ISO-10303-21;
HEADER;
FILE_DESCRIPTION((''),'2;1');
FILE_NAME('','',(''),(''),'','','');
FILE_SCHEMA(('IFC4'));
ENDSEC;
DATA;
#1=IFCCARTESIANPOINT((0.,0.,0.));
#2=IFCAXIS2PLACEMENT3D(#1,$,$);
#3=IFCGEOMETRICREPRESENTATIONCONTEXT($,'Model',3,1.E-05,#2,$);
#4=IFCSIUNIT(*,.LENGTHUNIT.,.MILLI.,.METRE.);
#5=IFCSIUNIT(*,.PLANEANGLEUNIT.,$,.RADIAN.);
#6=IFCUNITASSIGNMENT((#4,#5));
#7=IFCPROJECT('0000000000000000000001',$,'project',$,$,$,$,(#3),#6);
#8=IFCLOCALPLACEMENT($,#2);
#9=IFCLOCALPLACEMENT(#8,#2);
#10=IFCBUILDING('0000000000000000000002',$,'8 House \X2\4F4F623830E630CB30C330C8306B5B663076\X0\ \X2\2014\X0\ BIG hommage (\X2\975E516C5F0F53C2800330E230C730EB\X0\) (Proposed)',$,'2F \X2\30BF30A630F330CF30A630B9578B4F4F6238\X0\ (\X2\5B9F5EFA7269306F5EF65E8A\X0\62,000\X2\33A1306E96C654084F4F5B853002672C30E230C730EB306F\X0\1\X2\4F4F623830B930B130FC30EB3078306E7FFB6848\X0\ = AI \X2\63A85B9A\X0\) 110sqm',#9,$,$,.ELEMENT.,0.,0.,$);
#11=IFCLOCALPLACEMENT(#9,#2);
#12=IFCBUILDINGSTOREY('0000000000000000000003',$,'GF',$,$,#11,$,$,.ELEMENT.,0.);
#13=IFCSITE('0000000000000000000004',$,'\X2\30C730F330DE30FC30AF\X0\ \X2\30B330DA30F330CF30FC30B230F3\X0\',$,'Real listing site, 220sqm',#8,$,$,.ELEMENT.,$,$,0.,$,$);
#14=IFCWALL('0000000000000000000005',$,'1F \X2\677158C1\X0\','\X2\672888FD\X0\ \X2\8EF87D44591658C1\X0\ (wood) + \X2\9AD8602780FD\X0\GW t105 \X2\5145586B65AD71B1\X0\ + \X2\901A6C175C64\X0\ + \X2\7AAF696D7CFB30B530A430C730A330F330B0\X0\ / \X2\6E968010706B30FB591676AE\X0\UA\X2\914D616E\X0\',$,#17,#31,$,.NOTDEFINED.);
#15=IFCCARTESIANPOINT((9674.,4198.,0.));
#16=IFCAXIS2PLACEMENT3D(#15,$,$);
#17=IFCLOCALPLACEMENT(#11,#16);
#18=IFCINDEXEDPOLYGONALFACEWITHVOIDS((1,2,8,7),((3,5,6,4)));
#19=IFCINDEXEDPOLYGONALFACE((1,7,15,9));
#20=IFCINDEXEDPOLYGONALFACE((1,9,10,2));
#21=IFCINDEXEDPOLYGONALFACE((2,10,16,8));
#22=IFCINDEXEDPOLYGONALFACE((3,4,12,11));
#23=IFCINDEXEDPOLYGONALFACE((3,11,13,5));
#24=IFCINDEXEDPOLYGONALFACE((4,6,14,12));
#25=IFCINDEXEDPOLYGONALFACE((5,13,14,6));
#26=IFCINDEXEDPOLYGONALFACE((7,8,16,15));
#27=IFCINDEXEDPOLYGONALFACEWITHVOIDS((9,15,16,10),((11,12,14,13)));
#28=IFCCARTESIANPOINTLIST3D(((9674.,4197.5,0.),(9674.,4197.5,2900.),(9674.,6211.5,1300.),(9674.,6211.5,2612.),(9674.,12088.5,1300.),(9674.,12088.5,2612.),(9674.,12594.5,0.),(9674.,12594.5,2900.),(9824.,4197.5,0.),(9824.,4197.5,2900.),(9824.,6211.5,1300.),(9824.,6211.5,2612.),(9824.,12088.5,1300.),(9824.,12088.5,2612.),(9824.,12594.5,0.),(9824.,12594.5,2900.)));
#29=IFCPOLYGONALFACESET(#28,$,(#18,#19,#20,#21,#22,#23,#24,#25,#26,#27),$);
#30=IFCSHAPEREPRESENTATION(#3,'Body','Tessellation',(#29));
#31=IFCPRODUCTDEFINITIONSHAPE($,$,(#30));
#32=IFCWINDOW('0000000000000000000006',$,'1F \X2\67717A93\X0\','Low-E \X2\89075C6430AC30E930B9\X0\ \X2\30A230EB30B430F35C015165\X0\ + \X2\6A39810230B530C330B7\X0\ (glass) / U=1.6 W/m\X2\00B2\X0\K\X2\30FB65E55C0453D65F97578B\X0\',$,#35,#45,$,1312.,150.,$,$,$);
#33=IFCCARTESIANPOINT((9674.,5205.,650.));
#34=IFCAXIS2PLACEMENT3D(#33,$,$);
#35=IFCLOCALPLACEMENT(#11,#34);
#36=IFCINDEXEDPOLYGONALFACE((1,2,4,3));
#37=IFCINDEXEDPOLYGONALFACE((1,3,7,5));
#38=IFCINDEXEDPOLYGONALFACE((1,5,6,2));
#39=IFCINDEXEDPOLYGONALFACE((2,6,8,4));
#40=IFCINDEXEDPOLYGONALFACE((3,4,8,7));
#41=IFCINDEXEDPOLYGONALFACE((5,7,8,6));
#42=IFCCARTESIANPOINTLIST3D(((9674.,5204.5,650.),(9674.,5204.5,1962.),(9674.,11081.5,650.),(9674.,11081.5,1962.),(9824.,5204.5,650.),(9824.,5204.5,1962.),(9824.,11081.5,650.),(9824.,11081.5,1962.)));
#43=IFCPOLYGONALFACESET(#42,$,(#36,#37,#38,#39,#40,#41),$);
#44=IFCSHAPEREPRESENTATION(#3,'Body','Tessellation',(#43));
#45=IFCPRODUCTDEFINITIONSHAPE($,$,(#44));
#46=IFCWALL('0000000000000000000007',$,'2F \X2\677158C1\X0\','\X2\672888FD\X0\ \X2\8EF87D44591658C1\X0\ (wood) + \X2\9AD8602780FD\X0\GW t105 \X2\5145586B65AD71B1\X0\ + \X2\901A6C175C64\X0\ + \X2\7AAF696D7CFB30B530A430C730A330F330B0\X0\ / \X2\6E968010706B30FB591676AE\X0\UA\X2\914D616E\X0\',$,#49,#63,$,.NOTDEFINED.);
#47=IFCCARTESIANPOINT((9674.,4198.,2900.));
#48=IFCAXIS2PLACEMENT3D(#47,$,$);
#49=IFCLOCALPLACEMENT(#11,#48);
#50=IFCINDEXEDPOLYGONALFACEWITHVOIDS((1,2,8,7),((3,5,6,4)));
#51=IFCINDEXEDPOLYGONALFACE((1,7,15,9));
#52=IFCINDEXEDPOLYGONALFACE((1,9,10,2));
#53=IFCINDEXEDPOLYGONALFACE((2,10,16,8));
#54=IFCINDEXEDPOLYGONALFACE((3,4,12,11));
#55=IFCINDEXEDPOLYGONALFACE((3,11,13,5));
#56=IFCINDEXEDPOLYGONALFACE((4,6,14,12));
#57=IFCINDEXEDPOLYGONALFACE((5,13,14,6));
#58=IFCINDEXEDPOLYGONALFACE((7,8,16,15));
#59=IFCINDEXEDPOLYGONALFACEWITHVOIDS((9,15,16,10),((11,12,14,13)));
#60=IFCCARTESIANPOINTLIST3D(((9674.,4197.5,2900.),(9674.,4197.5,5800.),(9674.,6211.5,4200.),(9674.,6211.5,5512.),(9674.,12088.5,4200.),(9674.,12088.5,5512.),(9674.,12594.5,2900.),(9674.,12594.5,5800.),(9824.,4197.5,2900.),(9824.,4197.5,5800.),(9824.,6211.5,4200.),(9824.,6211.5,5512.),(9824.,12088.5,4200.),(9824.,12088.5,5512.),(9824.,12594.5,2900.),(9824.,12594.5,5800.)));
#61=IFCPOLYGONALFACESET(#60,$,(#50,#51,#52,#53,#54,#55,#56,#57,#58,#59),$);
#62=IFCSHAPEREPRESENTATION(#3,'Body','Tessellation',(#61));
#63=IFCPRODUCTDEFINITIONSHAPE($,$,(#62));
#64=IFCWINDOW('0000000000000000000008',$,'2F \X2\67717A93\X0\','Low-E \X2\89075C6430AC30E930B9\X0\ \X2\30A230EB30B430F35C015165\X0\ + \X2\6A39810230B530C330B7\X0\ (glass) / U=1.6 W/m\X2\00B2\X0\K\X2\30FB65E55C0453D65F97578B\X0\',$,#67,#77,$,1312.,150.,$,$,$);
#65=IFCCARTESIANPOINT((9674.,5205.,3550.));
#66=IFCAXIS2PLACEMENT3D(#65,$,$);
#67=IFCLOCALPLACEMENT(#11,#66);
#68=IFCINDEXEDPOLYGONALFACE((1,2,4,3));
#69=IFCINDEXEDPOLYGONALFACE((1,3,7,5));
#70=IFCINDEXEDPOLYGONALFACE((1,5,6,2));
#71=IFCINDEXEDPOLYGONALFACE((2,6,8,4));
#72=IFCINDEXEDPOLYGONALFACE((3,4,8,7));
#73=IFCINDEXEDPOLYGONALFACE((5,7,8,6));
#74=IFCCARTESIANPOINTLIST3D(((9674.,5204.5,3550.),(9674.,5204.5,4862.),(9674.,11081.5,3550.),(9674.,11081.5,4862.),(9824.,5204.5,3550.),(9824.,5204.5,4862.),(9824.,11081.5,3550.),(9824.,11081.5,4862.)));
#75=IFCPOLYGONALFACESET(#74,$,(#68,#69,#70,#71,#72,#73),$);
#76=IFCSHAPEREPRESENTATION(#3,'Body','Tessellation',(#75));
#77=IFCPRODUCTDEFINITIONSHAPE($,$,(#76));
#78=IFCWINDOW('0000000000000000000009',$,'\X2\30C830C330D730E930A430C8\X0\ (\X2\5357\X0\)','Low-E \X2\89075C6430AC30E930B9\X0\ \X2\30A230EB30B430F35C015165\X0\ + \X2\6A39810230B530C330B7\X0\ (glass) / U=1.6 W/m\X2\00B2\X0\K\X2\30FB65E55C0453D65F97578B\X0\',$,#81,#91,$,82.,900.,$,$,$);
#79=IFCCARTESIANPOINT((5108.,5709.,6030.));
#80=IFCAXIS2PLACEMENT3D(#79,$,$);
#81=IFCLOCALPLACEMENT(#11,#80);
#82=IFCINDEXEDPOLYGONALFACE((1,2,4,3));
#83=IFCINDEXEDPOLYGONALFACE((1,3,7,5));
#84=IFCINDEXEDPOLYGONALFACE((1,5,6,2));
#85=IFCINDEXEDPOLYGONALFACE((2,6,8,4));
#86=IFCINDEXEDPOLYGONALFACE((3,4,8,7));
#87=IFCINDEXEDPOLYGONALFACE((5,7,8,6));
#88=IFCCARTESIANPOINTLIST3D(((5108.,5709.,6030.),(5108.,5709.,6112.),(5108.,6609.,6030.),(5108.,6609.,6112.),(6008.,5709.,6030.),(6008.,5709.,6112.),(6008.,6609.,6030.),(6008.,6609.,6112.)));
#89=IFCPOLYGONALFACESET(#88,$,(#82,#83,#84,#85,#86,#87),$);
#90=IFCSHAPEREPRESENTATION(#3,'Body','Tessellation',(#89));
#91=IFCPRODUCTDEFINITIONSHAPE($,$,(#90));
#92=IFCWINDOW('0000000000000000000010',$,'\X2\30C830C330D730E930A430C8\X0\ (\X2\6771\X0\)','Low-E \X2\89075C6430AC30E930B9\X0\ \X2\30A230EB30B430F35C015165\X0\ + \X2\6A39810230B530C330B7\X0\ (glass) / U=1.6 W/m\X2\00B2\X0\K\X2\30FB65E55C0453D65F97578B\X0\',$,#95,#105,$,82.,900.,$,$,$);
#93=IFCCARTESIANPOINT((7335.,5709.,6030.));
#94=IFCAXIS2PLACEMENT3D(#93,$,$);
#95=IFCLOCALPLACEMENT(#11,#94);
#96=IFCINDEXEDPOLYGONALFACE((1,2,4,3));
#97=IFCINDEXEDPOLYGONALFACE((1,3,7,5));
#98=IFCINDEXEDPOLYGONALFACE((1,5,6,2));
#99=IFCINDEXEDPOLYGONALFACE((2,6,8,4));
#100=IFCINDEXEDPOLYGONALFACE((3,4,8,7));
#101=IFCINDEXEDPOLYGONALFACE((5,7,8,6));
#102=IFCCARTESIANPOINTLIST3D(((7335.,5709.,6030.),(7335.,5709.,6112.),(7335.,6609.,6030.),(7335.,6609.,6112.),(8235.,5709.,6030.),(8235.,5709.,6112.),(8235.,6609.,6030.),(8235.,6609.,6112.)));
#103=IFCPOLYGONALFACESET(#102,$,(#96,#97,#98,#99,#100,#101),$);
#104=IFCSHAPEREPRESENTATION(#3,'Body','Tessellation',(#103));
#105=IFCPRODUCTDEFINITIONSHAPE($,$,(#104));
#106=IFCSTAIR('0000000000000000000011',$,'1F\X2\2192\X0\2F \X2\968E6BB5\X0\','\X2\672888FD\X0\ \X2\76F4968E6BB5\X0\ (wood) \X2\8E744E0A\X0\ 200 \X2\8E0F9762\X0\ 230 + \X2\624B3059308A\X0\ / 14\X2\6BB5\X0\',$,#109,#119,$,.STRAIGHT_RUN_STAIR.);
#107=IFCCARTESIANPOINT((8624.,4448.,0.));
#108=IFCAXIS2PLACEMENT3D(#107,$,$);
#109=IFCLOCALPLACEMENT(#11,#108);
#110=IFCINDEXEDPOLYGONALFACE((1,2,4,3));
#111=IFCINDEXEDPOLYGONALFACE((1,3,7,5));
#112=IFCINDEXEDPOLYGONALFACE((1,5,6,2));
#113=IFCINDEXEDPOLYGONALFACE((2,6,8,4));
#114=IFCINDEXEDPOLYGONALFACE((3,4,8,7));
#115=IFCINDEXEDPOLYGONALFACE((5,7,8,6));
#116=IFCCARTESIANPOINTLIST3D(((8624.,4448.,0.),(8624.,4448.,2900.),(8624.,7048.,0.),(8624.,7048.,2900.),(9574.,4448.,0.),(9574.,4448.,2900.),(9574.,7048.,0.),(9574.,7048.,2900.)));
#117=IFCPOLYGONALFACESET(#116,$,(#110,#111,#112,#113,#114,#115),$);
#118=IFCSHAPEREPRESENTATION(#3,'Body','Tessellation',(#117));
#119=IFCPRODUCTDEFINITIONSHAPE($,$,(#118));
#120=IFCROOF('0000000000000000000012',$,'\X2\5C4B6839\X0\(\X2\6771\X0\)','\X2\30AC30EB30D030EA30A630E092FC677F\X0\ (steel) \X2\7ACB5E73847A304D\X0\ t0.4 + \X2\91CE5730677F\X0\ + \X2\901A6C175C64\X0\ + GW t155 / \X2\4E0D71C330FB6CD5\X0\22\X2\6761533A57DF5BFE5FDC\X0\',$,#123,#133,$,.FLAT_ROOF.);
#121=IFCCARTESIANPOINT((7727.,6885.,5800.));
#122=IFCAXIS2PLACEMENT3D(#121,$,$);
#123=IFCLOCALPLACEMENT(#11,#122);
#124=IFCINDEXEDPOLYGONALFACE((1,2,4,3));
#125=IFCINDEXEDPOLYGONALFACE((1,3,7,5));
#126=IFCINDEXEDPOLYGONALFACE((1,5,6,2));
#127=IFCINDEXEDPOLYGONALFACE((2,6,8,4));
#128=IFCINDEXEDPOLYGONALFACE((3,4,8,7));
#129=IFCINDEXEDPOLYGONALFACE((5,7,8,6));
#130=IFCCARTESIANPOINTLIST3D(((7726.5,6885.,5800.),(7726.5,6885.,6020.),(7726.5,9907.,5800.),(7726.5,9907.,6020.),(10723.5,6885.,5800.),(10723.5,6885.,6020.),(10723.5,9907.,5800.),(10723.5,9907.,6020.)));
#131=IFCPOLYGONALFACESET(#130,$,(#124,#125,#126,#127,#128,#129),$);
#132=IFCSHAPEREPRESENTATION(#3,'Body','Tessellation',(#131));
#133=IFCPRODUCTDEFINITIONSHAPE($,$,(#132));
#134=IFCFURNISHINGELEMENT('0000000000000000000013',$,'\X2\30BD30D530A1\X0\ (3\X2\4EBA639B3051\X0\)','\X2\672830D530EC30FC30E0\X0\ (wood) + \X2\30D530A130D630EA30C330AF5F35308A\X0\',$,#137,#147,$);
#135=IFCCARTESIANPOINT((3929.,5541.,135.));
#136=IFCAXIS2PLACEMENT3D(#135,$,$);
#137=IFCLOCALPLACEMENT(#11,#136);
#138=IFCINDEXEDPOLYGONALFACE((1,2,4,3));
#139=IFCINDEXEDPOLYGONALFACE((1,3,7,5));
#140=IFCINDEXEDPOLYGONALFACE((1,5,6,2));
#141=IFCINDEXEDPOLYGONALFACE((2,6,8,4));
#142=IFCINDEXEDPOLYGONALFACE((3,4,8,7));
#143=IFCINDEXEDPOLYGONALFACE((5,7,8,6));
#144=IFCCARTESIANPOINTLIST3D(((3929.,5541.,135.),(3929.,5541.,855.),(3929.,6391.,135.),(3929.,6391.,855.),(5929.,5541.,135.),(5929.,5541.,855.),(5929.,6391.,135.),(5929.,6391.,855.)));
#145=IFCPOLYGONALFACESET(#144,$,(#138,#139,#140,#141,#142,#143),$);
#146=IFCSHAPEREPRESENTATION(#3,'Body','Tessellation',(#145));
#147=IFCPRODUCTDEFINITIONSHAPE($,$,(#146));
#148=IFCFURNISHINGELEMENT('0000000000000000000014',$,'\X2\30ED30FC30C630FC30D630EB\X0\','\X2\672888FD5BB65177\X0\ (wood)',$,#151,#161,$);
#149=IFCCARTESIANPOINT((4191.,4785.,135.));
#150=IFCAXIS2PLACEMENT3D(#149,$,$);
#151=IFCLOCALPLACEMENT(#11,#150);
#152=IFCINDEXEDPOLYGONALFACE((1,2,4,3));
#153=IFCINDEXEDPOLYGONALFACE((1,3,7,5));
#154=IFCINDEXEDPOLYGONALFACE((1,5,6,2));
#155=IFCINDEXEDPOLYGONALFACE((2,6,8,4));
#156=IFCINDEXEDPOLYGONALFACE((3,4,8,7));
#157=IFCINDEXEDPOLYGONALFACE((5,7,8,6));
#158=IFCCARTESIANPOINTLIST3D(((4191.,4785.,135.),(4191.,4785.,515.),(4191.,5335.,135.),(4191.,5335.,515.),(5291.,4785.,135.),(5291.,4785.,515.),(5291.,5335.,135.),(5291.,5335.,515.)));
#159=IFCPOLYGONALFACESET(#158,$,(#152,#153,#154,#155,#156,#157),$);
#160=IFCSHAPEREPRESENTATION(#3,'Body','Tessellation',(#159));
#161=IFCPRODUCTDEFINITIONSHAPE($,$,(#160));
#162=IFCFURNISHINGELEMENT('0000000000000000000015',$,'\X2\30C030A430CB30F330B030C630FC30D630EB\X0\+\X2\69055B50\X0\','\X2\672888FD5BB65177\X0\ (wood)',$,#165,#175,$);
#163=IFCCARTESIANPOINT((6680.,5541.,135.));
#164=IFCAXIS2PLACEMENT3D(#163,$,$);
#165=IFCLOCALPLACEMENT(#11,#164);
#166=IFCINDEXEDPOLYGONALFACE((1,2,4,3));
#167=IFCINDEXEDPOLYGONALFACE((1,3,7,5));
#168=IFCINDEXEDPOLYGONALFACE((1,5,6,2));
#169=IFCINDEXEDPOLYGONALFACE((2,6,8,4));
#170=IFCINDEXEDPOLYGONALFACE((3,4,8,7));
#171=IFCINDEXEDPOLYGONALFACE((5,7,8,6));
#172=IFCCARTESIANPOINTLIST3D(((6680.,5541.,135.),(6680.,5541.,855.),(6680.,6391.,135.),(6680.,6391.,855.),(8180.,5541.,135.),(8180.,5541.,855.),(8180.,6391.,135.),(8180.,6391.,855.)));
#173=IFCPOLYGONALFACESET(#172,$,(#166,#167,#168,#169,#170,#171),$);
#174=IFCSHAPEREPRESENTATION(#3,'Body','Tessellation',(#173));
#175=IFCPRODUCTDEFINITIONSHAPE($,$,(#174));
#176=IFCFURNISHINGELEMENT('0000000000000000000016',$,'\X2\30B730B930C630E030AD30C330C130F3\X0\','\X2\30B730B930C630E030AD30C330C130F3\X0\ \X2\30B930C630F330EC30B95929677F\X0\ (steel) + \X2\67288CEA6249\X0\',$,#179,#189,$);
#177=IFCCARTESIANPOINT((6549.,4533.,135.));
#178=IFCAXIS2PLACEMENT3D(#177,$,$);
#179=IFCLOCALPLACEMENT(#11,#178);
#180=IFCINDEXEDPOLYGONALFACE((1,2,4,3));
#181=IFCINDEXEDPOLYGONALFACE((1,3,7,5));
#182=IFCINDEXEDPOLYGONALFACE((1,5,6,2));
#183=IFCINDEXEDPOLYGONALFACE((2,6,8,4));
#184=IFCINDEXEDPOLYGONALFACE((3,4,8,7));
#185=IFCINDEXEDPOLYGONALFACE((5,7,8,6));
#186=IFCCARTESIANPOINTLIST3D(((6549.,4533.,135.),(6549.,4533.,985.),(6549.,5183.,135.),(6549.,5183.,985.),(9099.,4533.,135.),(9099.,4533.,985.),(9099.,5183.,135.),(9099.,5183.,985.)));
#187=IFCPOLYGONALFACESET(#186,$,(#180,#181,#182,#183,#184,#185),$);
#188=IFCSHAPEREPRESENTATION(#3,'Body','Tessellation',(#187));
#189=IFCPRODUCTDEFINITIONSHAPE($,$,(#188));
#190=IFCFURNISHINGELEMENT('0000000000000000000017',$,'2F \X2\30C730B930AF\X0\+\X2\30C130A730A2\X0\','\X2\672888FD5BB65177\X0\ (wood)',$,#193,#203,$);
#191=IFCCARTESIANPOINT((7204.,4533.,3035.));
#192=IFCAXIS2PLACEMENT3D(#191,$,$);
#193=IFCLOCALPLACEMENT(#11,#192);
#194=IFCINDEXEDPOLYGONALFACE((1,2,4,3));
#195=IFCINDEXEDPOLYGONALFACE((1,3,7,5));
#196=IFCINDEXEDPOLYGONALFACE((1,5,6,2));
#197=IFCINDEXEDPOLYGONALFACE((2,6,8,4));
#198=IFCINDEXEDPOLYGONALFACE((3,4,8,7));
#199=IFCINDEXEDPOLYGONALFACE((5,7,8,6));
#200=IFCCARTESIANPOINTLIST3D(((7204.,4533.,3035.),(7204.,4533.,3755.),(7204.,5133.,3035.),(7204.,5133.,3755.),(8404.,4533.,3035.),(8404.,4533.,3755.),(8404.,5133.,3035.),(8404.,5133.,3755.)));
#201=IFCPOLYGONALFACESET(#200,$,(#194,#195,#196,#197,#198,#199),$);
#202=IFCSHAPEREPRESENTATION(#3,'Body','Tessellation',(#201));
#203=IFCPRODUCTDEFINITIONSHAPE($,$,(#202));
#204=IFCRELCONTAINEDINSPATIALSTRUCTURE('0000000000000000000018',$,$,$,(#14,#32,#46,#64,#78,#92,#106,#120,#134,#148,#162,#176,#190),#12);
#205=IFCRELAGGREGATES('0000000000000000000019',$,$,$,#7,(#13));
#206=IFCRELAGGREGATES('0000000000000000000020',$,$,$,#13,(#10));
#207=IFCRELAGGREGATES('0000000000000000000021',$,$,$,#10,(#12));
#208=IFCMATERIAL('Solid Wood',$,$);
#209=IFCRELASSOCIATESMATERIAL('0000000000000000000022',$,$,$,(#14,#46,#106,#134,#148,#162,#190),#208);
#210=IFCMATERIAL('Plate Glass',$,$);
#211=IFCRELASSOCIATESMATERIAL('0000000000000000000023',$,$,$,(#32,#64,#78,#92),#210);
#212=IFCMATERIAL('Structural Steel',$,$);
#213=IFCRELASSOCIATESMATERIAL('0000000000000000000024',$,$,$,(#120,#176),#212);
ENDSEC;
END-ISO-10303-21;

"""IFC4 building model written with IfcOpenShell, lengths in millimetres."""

from ifc_helpers import new_model, si_unit, frame, frame_2d, origin, place, context, project, spatial, rectangle, extrude, material, element, fill, save


model = new_model("IFC4")

# Units and contexts
model_context = context("Model", 3, precision=1e-05, world=origin())
ifc_project = project(units=[si_unit("LENGTHUNIT", "METRE", prefix="MILLI"), si_unit("PLANEANGLEUNIT", "RADIAN")], contexts=[model_context])

# Site, building, storey
site_placement = place(None, origin())
site = spatial("IfcSite", under=ifc_project, at=site_placement, Name="デンマーク コペンハーゲン", ObjectType="Real listing site, 220sqm", CompositionType="ELEMENT", RefElevation=0.0)
building_placement = place(site_placement, origin())
building = spatial("IfcBuilding", under=site, at=building_placement, Name="8 House 住戸ユニットに学ぶ — BIG hommage (非公式参考モデル) (Proposed)", ObjectType="2F タウンハウス型住戸 (実建物は延床62,000㎡の集合住宅。本モデルは1住戸スケールへの翻案 = AI 推定) 110sqm", CompositionType="ELEMENT", ElevationOfRefHeight=0.0, ElevationOfTerrain=0.0)
storey_placement = place(building_placement, origin())
storey = spatial("IfcBuildingStorey", under=building, at=storey_placement, Name="GF", CompositionType="ELEMENT", Elevation=0.0)

# Shared definitions
ifc_material_1 = material(Name="Solid Wood")

# Wall, opening, window
wall_1_placement = place(storey_placement, frame((9674.0, 4198.0, 0.0)))
wall_1 = element("IfcWall", 1, at=wall_1_placement, inside=storey, material=ifc_material_1, Name="1F 東壁", Description="木製 軸組外壁 (wood) + 高性能GW t105 充填断熱 + 通気層 + 窯業系サイディング / 準耐火・外皮UA配慮", PredefinedType="NOTDEFINED", context=model_context, shape_type="SweptSolid", body=[
    extrude(rectangle(XDim=150.0, YDim=8397.0, at=frame_2d((75.0, 4198.0))), frame((9674.0, 4198.0, 0.0)), (0.0, 0.0, 1.0), 2900.0),
])
opening_1_placement = place(storey_placement, frame((9674.0, 5205.0, 650.0)))
opening_1 = element("IfcOpeningElement", 2, at=opening_1_placement, cuts=wall_1, PredefinedType="NOTDEFINED", context=model_context, shape_type="SweptSolid", body=[
    extrude(rectangle(XDim=150.0, YDim=5877.0, at=frame_2d((75.0, 2938.0))), frame((9674.0, 5205.0, 650.0)), (0.0, 0.0, 1.0), 1312.0),
])
ifc_material_2 = material(Name="Plate Glass")
window_1_placement = place(storey_placement, frame((9674.0, 5205.0, 650.0)))
window_1 = element("IfcWindow", 3, at=window_1_placement, inside=storey, material=ifc_material_2, Name="1F 東窓", Description="Low-E 複層ガラス アルゴン封入 + 樹脂サッシ (glass) / U=1.6 W/m²K・日射取得型", OverallHeight=1312.0, OverallWidth=150.0, context=model_context, shape_type="SweptSolid", body=[
    extrude(rectangle(XDim=150.0, YDim=5877.0, at=frame_2d((75.0, 2938.0))), frame((9674.0, 5205.0, 650.0)), (0.0, 0.0, 1.0), 1312.0),
])
fill(opening_1, window_1)

# Wall, opening, window
wall_2_placement = place(storey_placement, frame((9674.0, 4198.0, 2900.0)))
wall_2 = element("IfcWall", 4, at=wall_2_placement, inside=storey, material=ifc_material_1, Name="2F 東壁", Description="木製 軸組外壁 (wood) + 高性能GW t105 充填断熱 + 通気層 + 窯業系サイディング / 準耐火・外皮UA配慮", PredefinedType="NOTDEFINED", context=model_context, shape_type="SweptSolid", body=[
    extrude(rectangle(XDim=150.0, YDim=8397.0, at=frame_2d((75.0, 4198.0))), frame((9674.0, 4198.0, 2900.0)), (0.0, 0.0, 1.0), 2900.0),
])
opening_2_placement = place(storey_placement, frame((9674.0, 5205.0, 3550.0)))
opening_2 = element("IfcOpeningElement", 5, at=opening_2_placement, cuts=wall_2, PredefinedType="NOTDEFINED", context=model_context, shape_type="SweptSolid", body=[
    extrude(rectangle(XDim=150.0, YDim=5877.0, at=frame_2d((75.0, 2938.0))), frame((9674.0, 5205.0, 3550.0)), (0.0, 0.0, 1.0), 1312.0),
])
window_2_placement = place(storey_placement, frame((9674.0, 5205.0, 3550.0)))
window_2 = element("IfcWindow", 6, at=window_2_placement, inside=storey, material=ifc_material_2, Name="2F 東窓", Description="Low-E 複層ガラス アルゴン封入 + 樹脂サッシ (glass) / U=1.6 W/m²K・日射取得型", OverallHeight=1312.0, OverallWidth=150.0, context=model_context, shape_type="SweptSolid", body=[
    extrude(rectangle(XDim=150.0, YDim=5877.0, at=frame_2d((75.0, 2938.0))), frame((9674.0, 5205.0, 3550.0)), (0.0, 0.0, 1.0), 1312.0),
])
fill(opening_2, window_2)

# Windows
window_3_placement = place(storey_placement, frame((5108.0, 5709.0, 6030.0)))
element("IfcWindow", 7, at=window_3_placement, inside=storey, material=ifc_material_2, Name="トップライト (南)", Description="Low-E 複層ガラス アルゴン封入 + 樹脂サッシ (glass) / U=1.6 W/m²K・日射取得型", OverallHeight=82.0, OverallWidth=900.0, context=model_context, shape_type="SweptSolid", body=[
    extrude(rectangle(XDim=900.0, YDim=900.0, at=frame_2d((450.0, 450.0))), frame((5108.0, 5709.0, 6030.0)), (0.0, 0.0, 1.0), 82.0),
])
window_4_placement = place(storey_placement, frame((7335.0, 5709.0, 6030.0)))
element("IfcWindow", 8, at=window_4_placement, inside=storey, material=ifc_material_2, Name="トップライト (東)", Description="Low-E 複層ガラス アルゴン封入 + 樹脂サッシ (glass) / U=1.6 W/m²K・日射取得型", OverallHeight=82.0, OverallWidth=900.0, context=model_context, shape_type="SweptSolid", body=[
    extrude(rectangle(XDim=900.0, YDim=900.0, at=frame_2d((450.0, 450.0))), frame((7335.0, 5709.0, 6030.0)), (0.0, 0.0, 1.0), 82.0),
])

# Stair
stair_placement = place(storey_placement, frame((8624.0, 4448.0, 0.0)))
element("IfcStair", 9, at=stair_placement, inside=storey, material=ifc_material_1, Name="1F→2F 階段", Description="木製 直階段 (wood) 蹴上 200 踏面 230 + 手すり / 14段", PredefinedType="STRAIGHT_RUN_STAIR", context=model_context, shape_type="SweptSolid", body=[
    extrude(rectangle(XDim=950.0, YDim=2600.0, at=frame_2d((475.0, 1300.0))), frame((8624.0, 4448.0, 0.0)), (0.0, 0.0, 1.0), 2900.0),
])

# Roof
ifc_material_3 = material(Name="Structural Steel")
roof_placement = place(storey_placement, frame((7727.0, 6885.0, 5800.0)))
element("IfcRoof", 10, at=roof_placement, inside=storey, material=ifc_material_3, Name="屋根(東)", Description="ガルバリウム鋼板 (steel) 立平葺き t0.4 + 野地板 + 通気層 + GW t155 / 不燃・法22条区域対応", PredefinedType="FLAT_ROOF", context=model_context, shape_type="SweptSolid", body=[
    extrude(rectangle(XDim=2997.0, YDim=3022.0, at=frame_2d((1498.0, 1511.0))), frame((7727.0, 6885.0, 5800.0)), (0.0, 0.0, 1.0), 220.0),
])

# Furnishing elements
furnishing_1_placement = place(storey_placement, frame((3929.0, 5541.0, 135.0)))
element("IfcFurnishingElement", 11, at=furnishing_1_placement, inside=storey, material=ifc_material_1, Name="ソファ (3人掛け)", Description="木フレーム (wood) + ファブリック張り", context=model_context, shape_type="SweptSolid", body=[
    extrude(rectangle(XDim=2000.0, YDim=850.0, at=frame_2d((1000.0, 425.0))), frame((3929.0, 5541.0, 135.0)), (0.0, 0.0, 1.0), 720.0),
])
furnishing_2_placement = place(storey_placement, frame((4191.0, 4785.0, 135.0)))
element("IfcFurnishingElement", 12, at=furnishing_2_placement, inside=storey, material=ifc_material_1, Name="ローテーブル", Description="木製家具 (wood)", context=model_context, shape_type="SweptSolid", body=[
    extrude(rectangle(XDim=1100.0, YDim=550.0, at=frame_2d((550.0, 275.0))), frame((4191.0, 4785.0, 135.0)), (0.0, 0.0, 1.0), 380.0),
])
furnishing_3_placement = place(storey_placement, frame((6680.0, 5541.0, 135.0)))
element("IfcFurnishingElement", 13, at=furnishing_3_placement, inside=storey, material=ifc_material_1, Name="ダイニングテーブル+椅子", Description="木製家具 (wood)", context=model_context, shape_type="SweptSolid", body=[
    extrude(rectangle(XDim=1500.0, YDim=850.0, at=frame_2d((750.0, 425.0))), frame((6680.0, 5541.0, 135.0)), (0.0, 0.0, 1.0), 720.0),
])
furnishing_4_placement = place(storey_placement, frame((6549.0, 4533.0, 135.0)))
element("IfcFurnishingElement", 14, at=furnishing_4_placement, inside=storey, material=ifc_material_3, Name="システムキッチン", Description="システムキッチン ステンレス天板 (steel) + 木質扉", context=model_context, shape_type="SweptSolid", body=[
    extrude(rectangle(XDim=2550.0, YDim=650.0, at=frame_2d((1275.0, 325.0))), frame((6549.0, 4533.0, 135.0)), (0.0, 0.0, 1.0), 850.0),
])
furnishing_5_placement = place(storey_placement, frame((7204.0, 4533.0, 3035.0)))
element("IfcFurnishingElement", 15, at=furnishing_5_placement, inside=storey, material=ifc_material_1, Name="2F デスク+チェア", Description="木製家具 (wood)", context=model_context, shape_type="SweptSolid", body=[
    extrude(rectangle(XDim=1200.0, YDim=600.0, at=frame_2d((600.0, 300.0))), frame((7204.0, 4533.0, 3035.0)), (0.0, 0.0, 1.0), 720.0),
])

save(model, "model.ifc")
